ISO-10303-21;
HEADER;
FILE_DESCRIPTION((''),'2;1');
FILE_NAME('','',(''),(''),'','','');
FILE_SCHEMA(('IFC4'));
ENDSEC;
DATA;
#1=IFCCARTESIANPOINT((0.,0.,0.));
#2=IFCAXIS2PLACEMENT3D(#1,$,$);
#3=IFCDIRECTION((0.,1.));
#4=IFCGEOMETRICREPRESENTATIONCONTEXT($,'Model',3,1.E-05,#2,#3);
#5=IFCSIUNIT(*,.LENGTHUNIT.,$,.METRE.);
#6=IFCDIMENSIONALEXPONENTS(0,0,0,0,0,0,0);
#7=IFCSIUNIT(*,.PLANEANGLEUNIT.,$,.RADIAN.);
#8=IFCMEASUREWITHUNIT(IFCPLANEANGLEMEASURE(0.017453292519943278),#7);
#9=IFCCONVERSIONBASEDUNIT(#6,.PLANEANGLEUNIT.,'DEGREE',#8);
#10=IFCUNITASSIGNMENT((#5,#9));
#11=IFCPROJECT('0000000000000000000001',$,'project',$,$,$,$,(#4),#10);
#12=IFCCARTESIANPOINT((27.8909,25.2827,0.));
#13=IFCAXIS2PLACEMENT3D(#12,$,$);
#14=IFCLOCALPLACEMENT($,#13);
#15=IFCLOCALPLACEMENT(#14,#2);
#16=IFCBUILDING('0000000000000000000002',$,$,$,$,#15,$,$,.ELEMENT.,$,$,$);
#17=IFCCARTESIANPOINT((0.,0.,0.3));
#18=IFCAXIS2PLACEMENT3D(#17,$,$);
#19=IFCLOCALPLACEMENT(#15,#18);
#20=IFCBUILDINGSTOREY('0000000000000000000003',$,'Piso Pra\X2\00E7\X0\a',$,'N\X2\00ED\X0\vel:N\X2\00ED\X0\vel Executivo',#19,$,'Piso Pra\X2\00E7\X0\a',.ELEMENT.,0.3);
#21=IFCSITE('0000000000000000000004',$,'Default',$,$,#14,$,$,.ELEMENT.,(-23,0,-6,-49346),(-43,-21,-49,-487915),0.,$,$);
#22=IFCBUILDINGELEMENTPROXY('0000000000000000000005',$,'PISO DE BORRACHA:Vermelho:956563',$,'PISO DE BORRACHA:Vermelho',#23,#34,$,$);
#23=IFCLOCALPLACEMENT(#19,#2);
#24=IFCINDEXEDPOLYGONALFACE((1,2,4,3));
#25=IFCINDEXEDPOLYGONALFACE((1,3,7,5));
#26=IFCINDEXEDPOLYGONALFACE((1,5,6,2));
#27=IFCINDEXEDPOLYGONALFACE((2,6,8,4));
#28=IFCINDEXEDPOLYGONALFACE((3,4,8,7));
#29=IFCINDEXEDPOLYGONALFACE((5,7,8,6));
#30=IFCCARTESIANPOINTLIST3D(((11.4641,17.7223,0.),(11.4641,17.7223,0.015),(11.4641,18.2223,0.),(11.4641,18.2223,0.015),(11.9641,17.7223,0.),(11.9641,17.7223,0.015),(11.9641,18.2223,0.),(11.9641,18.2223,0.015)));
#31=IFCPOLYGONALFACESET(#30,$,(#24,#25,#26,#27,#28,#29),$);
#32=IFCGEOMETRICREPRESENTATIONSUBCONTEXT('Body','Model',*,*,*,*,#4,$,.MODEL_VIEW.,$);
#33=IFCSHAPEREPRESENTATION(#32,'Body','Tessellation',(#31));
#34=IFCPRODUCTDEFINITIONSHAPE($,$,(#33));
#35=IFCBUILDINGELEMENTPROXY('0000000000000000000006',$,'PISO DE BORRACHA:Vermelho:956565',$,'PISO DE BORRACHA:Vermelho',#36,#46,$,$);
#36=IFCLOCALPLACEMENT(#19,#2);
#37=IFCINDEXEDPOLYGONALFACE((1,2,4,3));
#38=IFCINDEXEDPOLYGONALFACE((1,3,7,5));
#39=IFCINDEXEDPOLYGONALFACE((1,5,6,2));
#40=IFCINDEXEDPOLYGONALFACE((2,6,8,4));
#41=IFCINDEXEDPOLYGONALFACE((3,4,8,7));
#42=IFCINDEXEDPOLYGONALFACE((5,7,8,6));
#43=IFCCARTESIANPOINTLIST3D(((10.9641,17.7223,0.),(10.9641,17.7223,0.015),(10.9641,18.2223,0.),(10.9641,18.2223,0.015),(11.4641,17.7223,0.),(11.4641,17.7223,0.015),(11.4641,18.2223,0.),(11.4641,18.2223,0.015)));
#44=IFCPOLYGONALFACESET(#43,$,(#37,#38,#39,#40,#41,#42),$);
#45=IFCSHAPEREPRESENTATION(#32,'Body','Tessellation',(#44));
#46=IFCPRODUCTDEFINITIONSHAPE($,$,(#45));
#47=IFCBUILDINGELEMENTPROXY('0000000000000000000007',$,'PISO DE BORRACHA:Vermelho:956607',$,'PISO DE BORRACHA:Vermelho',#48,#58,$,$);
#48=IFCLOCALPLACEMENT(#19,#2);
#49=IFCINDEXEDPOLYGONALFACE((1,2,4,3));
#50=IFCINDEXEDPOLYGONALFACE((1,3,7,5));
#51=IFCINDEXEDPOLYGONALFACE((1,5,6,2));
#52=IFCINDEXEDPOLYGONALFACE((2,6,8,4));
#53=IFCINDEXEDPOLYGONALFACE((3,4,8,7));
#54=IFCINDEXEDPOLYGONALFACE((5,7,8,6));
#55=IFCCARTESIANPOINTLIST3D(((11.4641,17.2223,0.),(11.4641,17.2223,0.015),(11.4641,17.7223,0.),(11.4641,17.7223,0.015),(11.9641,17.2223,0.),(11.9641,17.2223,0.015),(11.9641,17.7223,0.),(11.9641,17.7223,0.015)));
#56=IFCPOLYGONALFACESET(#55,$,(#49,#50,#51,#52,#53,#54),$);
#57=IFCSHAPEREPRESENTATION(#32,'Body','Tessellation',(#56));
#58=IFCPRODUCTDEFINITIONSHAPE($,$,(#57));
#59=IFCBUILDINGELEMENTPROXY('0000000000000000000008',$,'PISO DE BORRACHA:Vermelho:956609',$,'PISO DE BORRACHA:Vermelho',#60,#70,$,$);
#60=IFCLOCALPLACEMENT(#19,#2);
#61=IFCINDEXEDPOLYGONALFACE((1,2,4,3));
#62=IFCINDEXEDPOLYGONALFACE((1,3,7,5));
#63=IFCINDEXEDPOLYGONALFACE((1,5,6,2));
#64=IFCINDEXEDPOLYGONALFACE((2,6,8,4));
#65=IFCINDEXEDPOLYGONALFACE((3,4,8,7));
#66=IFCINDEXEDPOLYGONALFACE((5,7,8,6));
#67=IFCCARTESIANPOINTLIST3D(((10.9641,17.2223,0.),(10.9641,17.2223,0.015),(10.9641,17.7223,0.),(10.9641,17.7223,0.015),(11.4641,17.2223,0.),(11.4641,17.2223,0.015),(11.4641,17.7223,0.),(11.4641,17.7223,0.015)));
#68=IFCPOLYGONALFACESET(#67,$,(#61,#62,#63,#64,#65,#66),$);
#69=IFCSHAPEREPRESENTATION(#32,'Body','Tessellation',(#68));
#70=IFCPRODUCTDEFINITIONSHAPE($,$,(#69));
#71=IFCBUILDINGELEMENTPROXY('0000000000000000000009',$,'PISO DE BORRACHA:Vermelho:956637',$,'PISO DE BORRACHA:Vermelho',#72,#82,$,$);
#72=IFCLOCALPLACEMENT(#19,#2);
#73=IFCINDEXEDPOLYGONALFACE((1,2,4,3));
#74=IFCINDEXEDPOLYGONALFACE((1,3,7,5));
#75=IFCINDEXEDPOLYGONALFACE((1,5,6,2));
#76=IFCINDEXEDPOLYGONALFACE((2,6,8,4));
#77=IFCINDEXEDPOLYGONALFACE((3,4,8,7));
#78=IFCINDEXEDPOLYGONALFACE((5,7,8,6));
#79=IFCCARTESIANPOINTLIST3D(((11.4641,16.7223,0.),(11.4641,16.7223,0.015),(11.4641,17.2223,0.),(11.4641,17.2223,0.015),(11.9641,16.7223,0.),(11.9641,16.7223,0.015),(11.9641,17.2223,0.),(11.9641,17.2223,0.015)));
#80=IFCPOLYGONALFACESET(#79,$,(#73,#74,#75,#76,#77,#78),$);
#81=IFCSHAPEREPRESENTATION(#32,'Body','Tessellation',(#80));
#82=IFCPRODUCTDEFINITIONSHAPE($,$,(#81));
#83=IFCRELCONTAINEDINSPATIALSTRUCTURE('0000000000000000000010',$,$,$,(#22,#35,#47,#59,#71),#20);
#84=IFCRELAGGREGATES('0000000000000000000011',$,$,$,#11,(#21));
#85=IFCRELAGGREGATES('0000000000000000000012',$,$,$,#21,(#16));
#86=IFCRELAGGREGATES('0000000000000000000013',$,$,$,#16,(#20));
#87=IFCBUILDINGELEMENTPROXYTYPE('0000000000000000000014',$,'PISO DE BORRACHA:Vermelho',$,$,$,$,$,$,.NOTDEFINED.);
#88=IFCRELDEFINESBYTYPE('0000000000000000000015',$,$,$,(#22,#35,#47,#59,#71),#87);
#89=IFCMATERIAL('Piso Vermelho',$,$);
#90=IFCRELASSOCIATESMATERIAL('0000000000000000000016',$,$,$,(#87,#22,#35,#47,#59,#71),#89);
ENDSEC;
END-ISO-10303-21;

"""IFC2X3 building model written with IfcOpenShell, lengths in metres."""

from ifc_helpers import new_model, entity, si_unit, converted_unit, direction, frame, origin, origin_2d_with_axis, place, context, subcontext, project, spatial, rectangle, extrude, source, transform, mapped, material, type_object, type_shapes, element, save


model = new_model("IFC2X3")

# Units and contexts
model_context = context("Model", 3, precision=1e-05, world=origin(), true_north=direction((0.0, 1.0)))
body_context = subcontext(model_context, "Body", "Model", "MODEL_VIEW")
ifc_project = project(units=[si_unit("LENGTHUNIT", "METRE"), converted_unit("PLANEANGLEUNIT", "DEGREE", entity("IfcPlaneAngleMeasure", 0.017453292519943278), si_unit("PLANEANGLEUNIT", "RADIAN"), dimensions=[0, 0, 0, 0, 0, 0, 0])], contexts=[model_context])

# Site, building, storey
site_placement = place(None, frame((27.8909, 25.2827, 0.0)))
site = spatial("IfcSite", under=ifc_project, at=site_placement, Name="Default", CompositionType="ELEMENT", RefLatitude=(-23, 0, -6, -49346), RefLongitude=(-43, -21, -49, -487915), RefElevation=0.0)
building_placement = place(site_placement, origin())
building = spatial("IfcBuilding", under=site, at=building_placement, CompositionType="ELEMENT")
storey_placement = place(building_placement, frame((0.0, 0.0, 0.3)))
storey = spatial("IfcBuildingStorey", under=building, at=storey_placement, Name="Piso Praça", ObjectType="Nível:Nível Executivo", LongName="Piso Praça", CompositionType="ELEMENT", Elevation=0.3)

# Building element proxies
ifc_material_1 = material(Name="Piso Vermelho")
building_element_proxy_type_1 = type_object("IfcBuildingElementProxyType", Name="PISO DE BORRACHA:Vermelho", PredefinedType="NOTDEFINED", material=ifc_material_1)
shared_shape_1 = source(origin(), body_context, "Body", "SweptSolid", [
    extrude(rectangle(XDim=0.5, YDim=0.5, at=origin_2d_with_axis()), frame((0.25, 0.25, 0.0), z_axis=(0.0, 0.0, 1.0), x_axis=(-1.0, 0.0, 0.0)), (0.0, 0.0, 1.0), 0.015),
])
type_shapes(building_element_proxy_type_1, [shared_shape_1])
for number, where, name in (
    (1, (11.4641, 17.7223, 0.0), "PISO DE BORRACHA:Vermelho:956563"),
    (2, (10.9641, 17.7223, 0.0), "PISO DE BORRACHA:Vermelho:956565"),
    (3, (11.4641, 17.2223, 0.0), "PISO DE BORRACHA:Vermelho:956607"),
    (4, (10.9641, 17.2223, 0.0), "PISO DE BORRACHA:Vermelho:956609"),
    (5, (11.4641, 16.7223, 0.0), "PISO DE BORRACHA:Vermelho:956637"),
):
    element("IfcBuildingElementProxy", number, at=place(storey_placement, frame(where)), inside=storey, type_object=building_element_proxy_type_1, material=ifc_material_1, Name=name, ObjectType="PISO DE BORRACHA:Vermelho", context=body_context, shape_type="MappedRepresentation", body=[
        mapped(shared_shape_1, transform((0.0, 0.0, 0.0), scale=1.0)),
    ])

save(model, "model.ifc")
